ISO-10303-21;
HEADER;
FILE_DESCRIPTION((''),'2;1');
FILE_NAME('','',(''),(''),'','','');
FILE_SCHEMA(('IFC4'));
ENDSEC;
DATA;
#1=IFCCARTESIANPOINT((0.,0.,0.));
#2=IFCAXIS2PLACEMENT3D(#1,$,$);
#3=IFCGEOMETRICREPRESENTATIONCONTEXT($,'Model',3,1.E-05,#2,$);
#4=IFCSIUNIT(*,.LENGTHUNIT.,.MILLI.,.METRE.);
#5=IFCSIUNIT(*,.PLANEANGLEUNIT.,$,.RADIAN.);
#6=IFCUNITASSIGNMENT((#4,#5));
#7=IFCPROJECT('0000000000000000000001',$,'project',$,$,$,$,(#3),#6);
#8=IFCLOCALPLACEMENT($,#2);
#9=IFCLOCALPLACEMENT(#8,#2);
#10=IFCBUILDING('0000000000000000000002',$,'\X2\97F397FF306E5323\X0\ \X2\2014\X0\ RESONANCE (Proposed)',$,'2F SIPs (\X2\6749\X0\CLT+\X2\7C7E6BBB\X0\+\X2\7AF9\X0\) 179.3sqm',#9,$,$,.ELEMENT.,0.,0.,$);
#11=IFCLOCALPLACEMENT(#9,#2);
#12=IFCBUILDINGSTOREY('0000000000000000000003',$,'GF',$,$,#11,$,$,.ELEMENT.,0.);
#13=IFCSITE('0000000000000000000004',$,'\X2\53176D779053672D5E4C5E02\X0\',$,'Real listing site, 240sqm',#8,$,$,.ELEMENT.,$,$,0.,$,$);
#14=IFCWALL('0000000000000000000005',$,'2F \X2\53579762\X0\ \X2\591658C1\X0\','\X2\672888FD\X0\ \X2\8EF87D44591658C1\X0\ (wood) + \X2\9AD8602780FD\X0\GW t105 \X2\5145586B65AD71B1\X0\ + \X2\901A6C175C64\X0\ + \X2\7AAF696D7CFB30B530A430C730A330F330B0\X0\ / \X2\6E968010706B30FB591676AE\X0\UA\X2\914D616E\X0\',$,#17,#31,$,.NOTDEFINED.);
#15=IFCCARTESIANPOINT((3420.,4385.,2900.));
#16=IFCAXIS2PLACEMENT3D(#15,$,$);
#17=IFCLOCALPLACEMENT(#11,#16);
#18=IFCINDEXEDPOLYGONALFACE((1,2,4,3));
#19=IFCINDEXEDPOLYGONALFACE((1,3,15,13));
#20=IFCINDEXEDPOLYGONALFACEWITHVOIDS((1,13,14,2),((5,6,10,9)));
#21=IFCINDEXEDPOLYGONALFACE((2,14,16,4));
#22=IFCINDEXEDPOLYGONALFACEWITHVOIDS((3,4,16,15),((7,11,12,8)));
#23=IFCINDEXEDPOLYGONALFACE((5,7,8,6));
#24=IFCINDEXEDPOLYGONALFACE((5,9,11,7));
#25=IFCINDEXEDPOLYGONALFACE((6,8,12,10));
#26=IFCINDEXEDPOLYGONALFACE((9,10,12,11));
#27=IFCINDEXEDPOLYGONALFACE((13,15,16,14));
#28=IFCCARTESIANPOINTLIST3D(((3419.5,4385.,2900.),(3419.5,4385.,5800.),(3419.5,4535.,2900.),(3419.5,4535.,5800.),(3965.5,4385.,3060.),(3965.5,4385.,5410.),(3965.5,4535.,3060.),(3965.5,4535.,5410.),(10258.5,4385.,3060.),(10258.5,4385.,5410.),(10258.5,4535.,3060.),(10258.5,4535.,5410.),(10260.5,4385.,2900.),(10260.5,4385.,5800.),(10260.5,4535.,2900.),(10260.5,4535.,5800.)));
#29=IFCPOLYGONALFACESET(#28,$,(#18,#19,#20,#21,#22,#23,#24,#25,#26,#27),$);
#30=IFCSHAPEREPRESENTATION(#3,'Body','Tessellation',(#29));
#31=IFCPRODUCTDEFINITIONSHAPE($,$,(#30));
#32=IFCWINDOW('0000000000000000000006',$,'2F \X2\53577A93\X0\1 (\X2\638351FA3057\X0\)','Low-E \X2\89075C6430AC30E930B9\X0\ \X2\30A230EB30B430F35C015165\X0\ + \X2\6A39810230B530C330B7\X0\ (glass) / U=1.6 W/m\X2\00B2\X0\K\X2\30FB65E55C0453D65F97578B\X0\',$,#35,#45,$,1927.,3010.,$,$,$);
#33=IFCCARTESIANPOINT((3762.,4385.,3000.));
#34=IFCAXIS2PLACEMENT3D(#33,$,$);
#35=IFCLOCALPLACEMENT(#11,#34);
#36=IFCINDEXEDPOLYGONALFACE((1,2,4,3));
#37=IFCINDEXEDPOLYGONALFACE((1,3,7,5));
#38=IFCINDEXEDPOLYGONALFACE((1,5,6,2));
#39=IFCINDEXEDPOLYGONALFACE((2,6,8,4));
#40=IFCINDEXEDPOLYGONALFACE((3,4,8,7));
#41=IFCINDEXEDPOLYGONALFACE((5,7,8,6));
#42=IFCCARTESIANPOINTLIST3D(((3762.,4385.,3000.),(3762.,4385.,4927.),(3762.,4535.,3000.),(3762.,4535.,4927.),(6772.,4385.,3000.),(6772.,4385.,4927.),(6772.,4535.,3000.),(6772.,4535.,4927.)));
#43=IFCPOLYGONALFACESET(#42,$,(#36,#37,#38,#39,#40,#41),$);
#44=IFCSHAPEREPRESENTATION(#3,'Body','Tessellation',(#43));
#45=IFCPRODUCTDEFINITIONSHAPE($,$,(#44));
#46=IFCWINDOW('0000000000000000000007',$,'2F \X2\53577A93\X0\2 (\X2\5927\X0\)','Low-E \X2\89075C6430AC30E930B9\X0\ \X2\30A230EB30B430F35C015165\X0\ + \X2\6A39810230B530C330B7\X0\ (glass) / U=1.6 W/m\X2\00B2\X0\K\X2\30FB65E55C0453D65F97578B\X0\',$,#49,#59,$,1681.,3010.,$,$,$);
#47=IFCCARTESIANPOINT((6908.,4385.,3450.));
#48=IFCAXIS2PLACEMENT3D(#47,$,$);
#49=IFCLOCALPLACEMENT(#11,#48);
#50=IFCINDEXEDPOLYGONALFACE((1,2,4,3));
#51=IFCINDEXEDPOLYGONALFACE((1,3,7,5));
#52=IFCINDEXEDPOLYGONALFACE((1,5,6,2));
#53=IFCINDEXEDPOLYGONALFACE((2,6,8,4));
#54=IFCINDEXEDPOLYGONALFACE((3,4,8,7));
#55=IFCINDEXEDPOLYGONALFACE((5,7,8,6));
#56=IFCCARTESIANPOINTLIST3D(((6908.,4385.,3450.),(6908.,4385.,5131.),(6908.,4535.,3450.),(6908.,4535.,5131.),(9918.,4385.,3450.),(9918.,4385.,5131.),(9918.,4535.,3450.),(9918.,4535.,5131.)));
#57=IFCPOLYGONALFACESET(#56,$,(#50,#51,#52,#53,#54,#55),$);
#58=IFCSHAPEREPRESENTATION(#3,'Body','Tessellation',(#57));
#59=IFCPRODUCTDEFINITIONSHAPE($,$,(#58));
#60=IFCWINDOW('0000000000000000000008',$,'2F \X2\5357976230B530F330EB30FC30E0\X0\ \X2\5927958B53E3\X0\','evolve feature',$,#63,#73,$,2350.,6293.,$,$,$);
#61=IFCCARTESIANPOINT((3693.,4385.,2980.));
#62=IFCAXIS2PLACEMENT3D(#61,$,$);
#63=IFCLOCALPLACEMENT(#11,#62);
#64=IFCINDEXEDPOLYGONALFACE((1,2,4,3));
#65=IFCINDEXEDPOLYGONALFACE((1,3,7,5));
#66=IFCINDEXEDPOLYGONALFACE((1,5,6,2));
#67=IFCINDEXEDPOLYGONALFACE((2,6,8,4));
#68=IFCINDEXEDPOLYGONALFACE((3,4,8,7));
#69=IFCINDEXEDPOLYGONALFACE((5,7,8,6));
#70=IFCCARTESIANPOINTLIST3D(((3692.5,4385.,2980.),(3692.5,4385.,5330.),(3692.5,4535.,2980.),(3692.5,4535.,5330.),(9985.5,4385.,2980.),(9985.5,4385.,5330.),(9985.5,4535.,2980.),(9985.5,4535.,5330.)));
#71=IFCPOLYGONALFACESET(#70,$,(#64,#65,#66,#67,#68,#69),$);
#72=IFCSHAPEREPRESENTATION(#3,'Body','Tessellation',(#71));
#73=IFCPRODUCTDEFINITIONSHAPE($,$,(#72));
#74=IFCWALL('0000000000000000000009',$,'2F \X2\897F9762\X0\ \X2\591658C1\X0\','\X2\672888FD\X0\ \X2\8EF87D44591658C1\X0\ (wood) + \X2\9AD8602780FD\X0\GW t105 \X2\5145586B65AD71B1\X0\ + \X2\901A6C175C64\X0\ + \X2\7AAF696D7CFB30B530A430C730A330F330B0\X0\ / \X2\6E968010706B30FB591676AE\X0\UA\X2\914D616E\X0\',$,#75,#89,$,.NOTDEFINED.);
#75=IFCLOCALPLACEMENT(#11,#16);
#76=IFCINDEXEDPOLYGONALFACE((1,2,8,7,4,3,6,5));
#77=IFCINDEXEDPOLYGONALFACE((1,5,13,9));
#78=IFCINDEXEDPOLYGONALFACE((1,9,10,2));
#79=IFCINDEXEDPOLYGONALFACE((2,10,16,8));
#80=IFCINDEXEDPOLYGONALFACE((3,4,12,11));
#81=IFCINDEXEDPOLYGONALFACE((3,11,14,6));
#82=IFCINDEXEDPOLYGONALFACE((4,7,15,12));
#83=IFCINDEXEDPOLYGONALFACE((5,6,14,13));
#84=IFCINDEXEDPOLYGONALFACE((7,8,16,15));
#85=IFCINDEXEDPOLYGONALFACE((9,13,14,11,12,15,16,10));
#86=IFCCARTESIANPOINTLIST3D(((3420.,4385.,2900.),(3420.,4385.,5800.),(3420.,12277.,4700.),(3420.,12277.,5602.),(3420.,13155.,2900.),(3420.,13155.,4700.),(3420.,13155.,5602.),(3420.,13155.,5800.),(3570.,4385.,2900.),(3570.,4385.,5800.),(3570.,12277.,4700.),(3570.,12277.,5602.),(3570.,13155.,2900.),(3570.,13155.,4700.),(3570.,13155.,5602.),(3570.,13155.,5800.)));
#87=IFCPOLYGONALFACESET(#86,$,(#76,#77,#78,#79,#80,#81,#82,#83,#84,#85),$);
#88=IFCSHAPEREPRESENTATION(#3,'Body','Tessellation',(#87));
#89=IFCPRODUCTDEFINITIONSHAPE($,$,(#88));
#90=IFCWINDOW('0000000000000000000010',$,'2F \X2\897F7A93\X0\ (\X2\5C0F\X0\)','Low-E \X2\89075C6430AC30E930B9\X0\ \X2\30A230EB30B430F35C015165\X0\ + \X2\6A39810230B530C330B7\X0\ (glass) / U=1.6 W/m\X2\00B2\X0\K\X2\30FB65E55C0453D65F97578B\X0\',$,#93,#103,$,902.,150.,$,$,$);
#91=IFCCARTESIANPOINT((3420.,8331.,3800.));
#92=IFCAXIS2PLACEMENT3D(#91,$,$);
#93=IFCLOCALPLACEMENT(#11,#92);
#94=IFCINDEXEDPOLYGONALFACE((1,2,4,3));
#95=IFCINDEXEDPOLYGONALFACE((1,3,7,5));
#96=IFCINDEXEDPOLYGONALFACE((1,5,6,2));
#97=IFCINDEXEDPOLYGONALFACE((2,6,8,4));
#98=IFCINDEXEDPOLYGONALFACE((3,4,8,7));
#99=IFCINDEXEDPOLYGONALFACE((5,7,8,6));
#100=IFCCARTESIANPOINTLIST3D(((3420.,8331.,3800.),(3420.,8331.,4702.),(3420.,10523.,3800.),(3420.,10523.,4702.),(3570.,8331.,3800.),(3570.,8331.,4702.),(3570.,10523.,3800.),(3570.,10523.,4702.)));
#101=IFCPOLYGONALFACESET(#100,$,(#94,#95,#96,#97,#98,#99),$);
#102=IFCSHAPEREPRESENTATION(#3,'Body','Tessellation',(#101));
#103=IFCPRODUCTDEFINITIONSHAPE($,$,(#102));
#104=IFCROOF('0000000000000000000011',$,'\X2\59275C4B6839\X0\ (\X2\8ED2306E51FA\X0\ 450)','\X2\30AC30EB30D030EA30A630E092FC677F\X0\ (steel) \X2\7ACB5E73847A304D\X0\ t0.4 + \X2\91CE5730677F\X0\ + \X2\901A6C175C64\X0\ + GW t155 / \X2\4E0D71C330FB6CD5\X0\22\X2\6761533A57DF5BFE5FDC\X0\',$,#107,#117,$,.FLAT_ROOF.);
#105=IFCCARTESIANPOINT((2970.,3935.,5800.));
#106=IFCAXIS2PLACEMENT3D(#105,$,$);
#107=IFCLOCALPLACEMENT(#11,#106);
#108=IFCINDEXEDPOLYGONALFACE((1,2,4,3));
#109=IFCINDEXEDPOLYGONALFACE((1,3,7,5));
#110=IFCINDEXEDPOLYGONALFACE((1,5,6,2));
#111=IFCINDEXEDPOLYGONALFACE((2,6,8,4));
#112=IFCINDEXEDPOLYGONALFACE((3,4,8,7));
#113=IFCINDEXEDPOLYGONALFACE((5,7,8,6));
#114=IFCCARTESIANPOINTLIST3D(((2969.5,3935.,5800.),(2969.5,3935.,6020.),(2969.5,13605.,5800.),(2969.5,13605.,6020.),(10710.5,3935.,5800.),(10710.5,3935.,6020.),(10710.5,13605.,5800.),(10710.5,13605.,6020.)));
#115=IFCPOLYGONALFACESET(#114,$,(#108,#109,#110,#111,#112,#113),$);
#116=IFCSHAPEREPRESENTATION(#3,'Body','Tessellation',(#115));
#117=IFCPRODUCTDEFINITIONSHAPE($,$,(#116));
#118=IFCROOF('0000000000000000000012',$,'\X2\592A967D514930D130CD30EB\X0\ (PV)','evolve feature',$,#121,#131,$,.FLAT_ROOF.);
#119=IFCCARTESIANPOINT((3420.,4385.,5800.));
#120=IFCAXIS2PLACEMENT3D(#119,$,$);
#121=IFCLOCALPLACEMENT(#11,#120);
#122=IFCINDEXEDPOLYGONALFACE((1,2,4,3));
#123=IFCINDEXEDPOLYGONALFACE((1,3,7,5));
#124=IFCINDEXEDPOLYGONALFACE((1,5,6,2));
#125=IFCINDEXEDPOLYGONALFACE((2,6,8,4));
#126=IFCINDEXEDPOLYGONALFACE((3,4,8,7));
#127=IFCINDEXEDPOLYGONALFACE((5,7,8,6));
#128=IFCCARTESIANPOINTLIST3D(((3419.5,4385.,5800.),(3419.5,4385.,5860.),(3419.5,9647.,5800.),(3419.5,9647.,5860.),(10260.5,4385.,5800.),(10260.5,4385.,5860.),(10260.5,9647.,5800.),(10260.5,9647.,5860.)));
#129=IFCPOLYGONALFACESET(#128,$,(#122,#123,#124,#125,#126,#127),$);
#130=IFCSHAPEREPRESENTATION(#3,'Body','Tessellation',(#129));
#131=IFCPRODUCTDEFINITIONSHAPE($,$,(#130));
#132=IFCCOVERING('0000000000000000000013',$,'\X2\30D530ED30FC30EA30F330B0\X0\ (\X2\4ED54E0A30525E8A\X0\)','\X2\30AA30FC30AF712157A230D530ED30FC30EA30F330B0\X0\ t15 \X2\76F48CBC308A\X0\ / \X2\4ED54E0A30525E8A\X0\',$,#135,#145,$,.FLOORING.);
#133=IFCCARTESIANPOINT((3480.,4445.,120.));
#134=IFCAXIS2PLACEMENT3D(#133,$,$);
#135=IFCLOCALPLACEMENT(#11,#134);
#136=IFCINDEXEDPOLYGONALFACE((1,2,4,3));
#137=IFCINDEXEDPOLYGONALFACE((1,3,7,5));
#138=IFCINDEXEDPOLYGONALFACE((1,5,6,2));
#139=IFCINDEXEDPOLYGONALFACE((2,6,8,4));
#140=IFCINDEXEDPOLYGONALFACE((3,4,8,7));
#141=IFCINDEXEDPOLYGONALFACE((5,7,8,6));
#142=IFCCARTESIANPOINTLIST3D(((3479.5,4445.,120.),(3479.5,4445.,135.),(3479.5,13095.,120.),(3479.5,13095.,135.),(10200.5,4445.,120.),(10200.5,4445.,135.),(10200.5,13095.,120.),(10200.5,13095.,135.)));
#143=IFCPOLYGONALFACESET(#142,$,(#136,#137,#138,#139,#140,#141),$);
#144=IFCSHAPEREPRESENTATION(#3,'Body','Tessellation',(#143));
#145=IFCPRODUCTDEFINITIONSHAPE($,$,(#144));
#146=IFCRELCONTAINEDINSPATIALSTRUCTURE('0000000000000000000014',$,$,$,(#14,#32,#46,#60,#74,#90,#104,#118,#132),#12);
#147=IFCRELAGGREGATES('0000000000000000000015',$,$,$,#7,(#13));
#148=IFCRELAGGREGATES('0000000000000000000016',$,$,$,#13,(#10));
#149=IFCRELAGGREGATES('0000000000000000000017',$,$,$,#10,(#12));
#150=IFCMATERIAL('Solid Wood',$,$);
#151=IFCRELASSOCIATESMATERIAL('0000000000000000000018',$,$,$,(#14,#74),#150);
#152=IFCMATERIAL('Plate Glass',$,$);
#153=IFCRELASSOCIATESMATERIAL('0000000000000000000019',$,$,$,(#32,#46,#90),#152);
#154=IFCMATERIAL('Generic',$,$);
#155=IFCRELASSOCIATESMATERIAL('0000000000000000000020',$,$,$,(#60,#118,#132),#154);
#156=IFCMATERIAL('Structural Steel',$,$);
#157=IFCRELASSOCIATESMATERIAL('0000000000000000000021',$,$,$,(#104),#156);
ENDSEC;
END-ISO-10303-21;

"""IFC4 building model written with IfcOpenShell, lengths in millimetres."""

from ifc_helpers import new_model, si_unit, frame, frame_2d, origin, place, context, project, spatial, rectangle, extrude, material, element, fill, save


model = new_model("IFC4")

# Units and contexts
model_context = context("Model", 3, precision=1e-05, world=origin())
ifc_project = project(units=[si_unit("LENGTHUNIT", "METRE", prefix="MILLI"), si_unit("PLANEANGLEUNIT", "RADIAN")], contexts=[model_context])

# Site, building, storey
site_placement = place(None, origin())
site = spatial("IfcSite", under=ifc_project, at=site_placement, Name="北海道札幌市", ObjectType="Real listing site, 240sqm", CompositionType="ELEMENT", RefElevation=0.0)
building_placement = place(site_placement, origin())
building = spatial("IfcBuilding", under=site, at=building_placement, Name="音響の匣 — RESONANCE (Proposed)", ObjectType="2F SIPs (杉CLT+籾殻+竹) 179.3sqm", CompositionType="ELEMENT", ElevationOfRefHeight=0.0, ElevationOfTerrain=0.0)
storey_placement = place(building_placement, origin())
storey = spatial("IfcBuildingStorey", under=building, at=storey_placement, Name="GF", CompositionType="ELEMENT", Elevation=0.0)

# Shared definitions
ifc_material_1 = material(Name="Solid Wood")

# Shared definitions
ifc_material_2 = material(Name="Plate Glass")
ifc_material_3 = material(Name="Generic")

# Wall, openings, windows
wall_1_placement = place(storey_placement, frame((3420.0, 4385.0, 2900.0)))
wall_1 = element("IfcWall", 1, at=wall_1_placement, inside=storey, material=ifc_material_1, Name="2F 南面 外壁", Description="木製 軸組外壁 (wood) + 高性能GW t105 充填断熱 + 通気層 + 窯業系サイディング / 準耐火・外皮UA配慮", PredefinedType="NOTDEFINED", context=model_context, shape_type="SweptSolid", body=[
    extrude(rectangle(XDim=6841.0, YDim=150.0, at=frame_2d((3420.0, 75.0))), frame((3420.0, 4385.0, 2900.0)), (0.0, 0.0, 1.0), 2900.0),
])
opening_1_placement = place(storey_placement, frame((3762.0, 4385.0, 3000.0)))
opening_1 = element("IfcOpeningElement", 2, at=opening_1_placement, cuts=wall_1, PredefinedType="NOTDEFINED", context=model_context, shape_type="SweptSolid", body=[
    extrude(rectangle(XDim=3010.0, YDim=150.0, at=frame_2d((1505.0, 75.0))), frame((3762.0, 4385.0, 3000.0)), (0.0, 0.0, 1.0), 1927.0),
])
opening_2_placement = place(storey_placement, frame((6908.0, 4385.0, 3450.0)))
opening_2 = element("IfcOpeningElement", 3, at=opening_2_placement, cuts=wall_1, PredefinedType="NOTDEFINED", context=model_context, shape_type="SweptSolid", body=[
    extrude(rectangle(XDim=3010.0, YDim=150.0, at=frame_2d((1505.0, 75.0))), frame((6908.0, 4385.0, 3450.0)), (0.0, 0.0, 1.0), 1681.0),
])
opening_3_placement = place(storey_placement, frame((3693.0, 4385.0, 2980.0)))
opening_3 = element("IfcOpeningElement", 4, at=opening_3_placement, cuts=wall_1, PredefinedType="NOTDEFINED", context=model_context, shape_type="SweptSolid", body=[
    extrude(rectangle(XDim=6293.0, YDim=150.0, at=frame_2d((3146.0, 75.0))), frame((3693.0, 4385.0, 2980.0)), (0.0, 0.0, 1.0), 2350.0),
])
window_1_placement = place(storey_placement, frame((3762.0, 4385.0, 3000.0)))
window_1 = element("IfcWindow", 5, at=window_1_placement, inside=storey, material=ifc_material_2, Name="2F 南窓1 (掃出し)", Description="Low-E 複層ガラス アルゴン封入 + 樹脂サッシ (glass) / U=1.6 W/m²K・日射取得型", OverallHeight=1927.0, OverallWidth=3010.0, context=model_context, shape_type="SweptSolid", body=[
    extrude(rectangle(XDim=3010.0, YDim=150.0, at=frame_2d((1505.0, 75.0))), frame((3762.0, 4385.0, 3000.0)), (0.0, 0.0, 1.0), 1927.0),
])
fill(opening_1, window_1)
window_2_placement = place(storey_placement, frame((6908.0, 4385.0, 3450.0)))
window_2 = element("IfcWindow", 6, at=window_2_placement, inside=storey, material=ifc_material_2, Name="2F 南窓2 (大)", Description="Low-E 複層ガラス アルゴン封入 + 樹脂サッシ (glass) / U=1.6 W/m²K・日射取得型", OverallHeight=1681.0, OverallWidth=3010.0, context=model_context, shape_type="SweptSolid", body=[
    extrude(rectangle(XDim=3010.0, YDim=150.0, at=frame_2d((1505.0, 75.0))), frame((6908.0, 4385.0, 3450.0)), (0.0, 0.0, 1.0), 1681.0),
])
fill(opening_2, window_2)
window_3_placement = place(storey_placement, frame((3693.0, 4385.0, 2980.0)))
window_3 = element("IfcWindow", 7, at=window_3_placement, inside=storey, material=ifc_material_3, Name="2F 南面サンルーム 大開口", Description="evolve feature", OverallHeight=2350.0, OverallWidth=6293.0, context=model_context, shape_type="SweptSolid", body=[
    extrude(rectangle(XDim=6293.0, YDim=150.0, at=frame_2d((3146.0, 75.0))), frame((3693.0, 4385.0, 2980.0)), (0.0, 0.0, 1.0), 2350.0),
])
fill(opening_3, window_3)

# Wall, opening, window
wall_2_placement = place(storey_placement, frame((3420.0, 4385.0, 2900.0)))
wall_2 = element("IfcWall", 8, at=wall_2_placement, inside=storey, material=ifc_material_1, Name="2F 西面 外壁", Description="木製 軸組外壁 (wood) + 高性能GW t105 充填断熱 + 通気層 + 窯業系サイディング / 準耐火・外皮UA配慮", PredefinedType="NOTDEFINED", context=model_context, shape_type="SweptSolid", body=[
    extrude(rectangle(XDim=150.0, YDim=8770.0, at=frame_2d((75.0, 4385.0))), frame((3420.0, 4385.0, 2900.0)), (0.0, 0.0, 1.0), 2900.0),
])
opening_4_placement = place(storey_placement, frame((3420.0, 8331.0, 3800.0)))
opening_4 = element("IfcOpeningElement", 9, at=opening_4_placement, cuts=wall_2, PredefinedType="NOTDEFINED", context=model_context, shape_type="SweptSolid", body=[
    extrude(rectangle(XDim=150.0, YDim=2192.0, at=frame_2d((75.0, 1096.0))), frame((3420.0, 8331.0, 3800.0)), (0.0, 0.0, 1.0), 902.0),
])
window_4_placement = place(storey_placement, frame((3420.0, 8331.0, 3800.0)))
window_4 = element("IfcWindow", 10, at=window_4_placement, inside=storey, material=ifc_material_2, Name="2F 西窓 (小)", Description="Low-E 複層ガラス アルゴン封入 + 樹脂サッシ (glass) / U=1.6 W/m²K・日射取得型", OverallHeight=902.0, OverallWidth=150.0, context=model_context, shape_type="SweptSolid", body=[
    extrude(rectangle(XDim=150.0, YDim=2192.0, at=frame_2d((75.0, 1096.0))), frame((3420.0, 8331.0, 3800.0)), (0.0, 0.0, 1.0), 902.0),
])
fill(opening_4, window_4)

# Roofs
ifc_material_4 = material(Name="Structural Steel")
roof_1_placement = place(storey_placement, frame((2970.0, 3935.0, 5800.0)))
element("IfcRoof", 11, at=roof_1_placement, inside=storey, material=ifc_material_4, Name="大屋根 (軒の出 450)", Description="ガルバリウム鋼板 (steel) 立平葺き t0.4 + 野地板 + 通気層 + GW t155 / 不燃・法22条区域対応", PredefinedType="FLAT_ROOF", context=model_context, shape_type="SweptSolid", body=[
    extrude(rectangle(XDim=7741.0, YDim=9670.0, at=frame_2d((3870.0, 4835.0))), frame((2970.0, 3935.0, 5800.0)), (0.0, 0.0, 1.0), 220.0),
])
roof_2_placement = place(storey_placement, frame((3420.0, 4385.0, 5800.0)))
element("IfcRoof", 12, at=roof_2_placement, inside=storey, material=ifc_material_3, Name="太陽光パネル (PV)", Description="evolve feature", PredefinedType="FLAT_ROOF", context=model_context, shape_type="SweptSolid", body=[
    extrude(rectangle(XDim=6841.0, YDim=5262.0, at=frame_2d((3420.0, 2631.0))), frame((3420.0, 4385.0, 5800.0)), (0.0, 0.0, 1.0), 60.0),
])

# Covering
covering_placement = place(storey_placement, frame((3480.0, 4445.0, 120.0)))
element("IfcCovering", 13, at=covering_placement, inside=storey, material=ifc_material_3, Name="フローリング (仕上げ床)", Description="オーク無垢フローリング t15 直貼り / 仕上げ床", PredefinedType="FLOORING", context=model_context, shape_type="SweptSolid", body=[
    extrude(rectangle(XDim=6721.0, YDim=8650.0, at=frame_2d((3360.0, 4325.0))), frame((3480.0, 4445.0, 120.0)), (0.0, 0.0, 1.0), 15.0),
])

save(model, "model.ifc")
